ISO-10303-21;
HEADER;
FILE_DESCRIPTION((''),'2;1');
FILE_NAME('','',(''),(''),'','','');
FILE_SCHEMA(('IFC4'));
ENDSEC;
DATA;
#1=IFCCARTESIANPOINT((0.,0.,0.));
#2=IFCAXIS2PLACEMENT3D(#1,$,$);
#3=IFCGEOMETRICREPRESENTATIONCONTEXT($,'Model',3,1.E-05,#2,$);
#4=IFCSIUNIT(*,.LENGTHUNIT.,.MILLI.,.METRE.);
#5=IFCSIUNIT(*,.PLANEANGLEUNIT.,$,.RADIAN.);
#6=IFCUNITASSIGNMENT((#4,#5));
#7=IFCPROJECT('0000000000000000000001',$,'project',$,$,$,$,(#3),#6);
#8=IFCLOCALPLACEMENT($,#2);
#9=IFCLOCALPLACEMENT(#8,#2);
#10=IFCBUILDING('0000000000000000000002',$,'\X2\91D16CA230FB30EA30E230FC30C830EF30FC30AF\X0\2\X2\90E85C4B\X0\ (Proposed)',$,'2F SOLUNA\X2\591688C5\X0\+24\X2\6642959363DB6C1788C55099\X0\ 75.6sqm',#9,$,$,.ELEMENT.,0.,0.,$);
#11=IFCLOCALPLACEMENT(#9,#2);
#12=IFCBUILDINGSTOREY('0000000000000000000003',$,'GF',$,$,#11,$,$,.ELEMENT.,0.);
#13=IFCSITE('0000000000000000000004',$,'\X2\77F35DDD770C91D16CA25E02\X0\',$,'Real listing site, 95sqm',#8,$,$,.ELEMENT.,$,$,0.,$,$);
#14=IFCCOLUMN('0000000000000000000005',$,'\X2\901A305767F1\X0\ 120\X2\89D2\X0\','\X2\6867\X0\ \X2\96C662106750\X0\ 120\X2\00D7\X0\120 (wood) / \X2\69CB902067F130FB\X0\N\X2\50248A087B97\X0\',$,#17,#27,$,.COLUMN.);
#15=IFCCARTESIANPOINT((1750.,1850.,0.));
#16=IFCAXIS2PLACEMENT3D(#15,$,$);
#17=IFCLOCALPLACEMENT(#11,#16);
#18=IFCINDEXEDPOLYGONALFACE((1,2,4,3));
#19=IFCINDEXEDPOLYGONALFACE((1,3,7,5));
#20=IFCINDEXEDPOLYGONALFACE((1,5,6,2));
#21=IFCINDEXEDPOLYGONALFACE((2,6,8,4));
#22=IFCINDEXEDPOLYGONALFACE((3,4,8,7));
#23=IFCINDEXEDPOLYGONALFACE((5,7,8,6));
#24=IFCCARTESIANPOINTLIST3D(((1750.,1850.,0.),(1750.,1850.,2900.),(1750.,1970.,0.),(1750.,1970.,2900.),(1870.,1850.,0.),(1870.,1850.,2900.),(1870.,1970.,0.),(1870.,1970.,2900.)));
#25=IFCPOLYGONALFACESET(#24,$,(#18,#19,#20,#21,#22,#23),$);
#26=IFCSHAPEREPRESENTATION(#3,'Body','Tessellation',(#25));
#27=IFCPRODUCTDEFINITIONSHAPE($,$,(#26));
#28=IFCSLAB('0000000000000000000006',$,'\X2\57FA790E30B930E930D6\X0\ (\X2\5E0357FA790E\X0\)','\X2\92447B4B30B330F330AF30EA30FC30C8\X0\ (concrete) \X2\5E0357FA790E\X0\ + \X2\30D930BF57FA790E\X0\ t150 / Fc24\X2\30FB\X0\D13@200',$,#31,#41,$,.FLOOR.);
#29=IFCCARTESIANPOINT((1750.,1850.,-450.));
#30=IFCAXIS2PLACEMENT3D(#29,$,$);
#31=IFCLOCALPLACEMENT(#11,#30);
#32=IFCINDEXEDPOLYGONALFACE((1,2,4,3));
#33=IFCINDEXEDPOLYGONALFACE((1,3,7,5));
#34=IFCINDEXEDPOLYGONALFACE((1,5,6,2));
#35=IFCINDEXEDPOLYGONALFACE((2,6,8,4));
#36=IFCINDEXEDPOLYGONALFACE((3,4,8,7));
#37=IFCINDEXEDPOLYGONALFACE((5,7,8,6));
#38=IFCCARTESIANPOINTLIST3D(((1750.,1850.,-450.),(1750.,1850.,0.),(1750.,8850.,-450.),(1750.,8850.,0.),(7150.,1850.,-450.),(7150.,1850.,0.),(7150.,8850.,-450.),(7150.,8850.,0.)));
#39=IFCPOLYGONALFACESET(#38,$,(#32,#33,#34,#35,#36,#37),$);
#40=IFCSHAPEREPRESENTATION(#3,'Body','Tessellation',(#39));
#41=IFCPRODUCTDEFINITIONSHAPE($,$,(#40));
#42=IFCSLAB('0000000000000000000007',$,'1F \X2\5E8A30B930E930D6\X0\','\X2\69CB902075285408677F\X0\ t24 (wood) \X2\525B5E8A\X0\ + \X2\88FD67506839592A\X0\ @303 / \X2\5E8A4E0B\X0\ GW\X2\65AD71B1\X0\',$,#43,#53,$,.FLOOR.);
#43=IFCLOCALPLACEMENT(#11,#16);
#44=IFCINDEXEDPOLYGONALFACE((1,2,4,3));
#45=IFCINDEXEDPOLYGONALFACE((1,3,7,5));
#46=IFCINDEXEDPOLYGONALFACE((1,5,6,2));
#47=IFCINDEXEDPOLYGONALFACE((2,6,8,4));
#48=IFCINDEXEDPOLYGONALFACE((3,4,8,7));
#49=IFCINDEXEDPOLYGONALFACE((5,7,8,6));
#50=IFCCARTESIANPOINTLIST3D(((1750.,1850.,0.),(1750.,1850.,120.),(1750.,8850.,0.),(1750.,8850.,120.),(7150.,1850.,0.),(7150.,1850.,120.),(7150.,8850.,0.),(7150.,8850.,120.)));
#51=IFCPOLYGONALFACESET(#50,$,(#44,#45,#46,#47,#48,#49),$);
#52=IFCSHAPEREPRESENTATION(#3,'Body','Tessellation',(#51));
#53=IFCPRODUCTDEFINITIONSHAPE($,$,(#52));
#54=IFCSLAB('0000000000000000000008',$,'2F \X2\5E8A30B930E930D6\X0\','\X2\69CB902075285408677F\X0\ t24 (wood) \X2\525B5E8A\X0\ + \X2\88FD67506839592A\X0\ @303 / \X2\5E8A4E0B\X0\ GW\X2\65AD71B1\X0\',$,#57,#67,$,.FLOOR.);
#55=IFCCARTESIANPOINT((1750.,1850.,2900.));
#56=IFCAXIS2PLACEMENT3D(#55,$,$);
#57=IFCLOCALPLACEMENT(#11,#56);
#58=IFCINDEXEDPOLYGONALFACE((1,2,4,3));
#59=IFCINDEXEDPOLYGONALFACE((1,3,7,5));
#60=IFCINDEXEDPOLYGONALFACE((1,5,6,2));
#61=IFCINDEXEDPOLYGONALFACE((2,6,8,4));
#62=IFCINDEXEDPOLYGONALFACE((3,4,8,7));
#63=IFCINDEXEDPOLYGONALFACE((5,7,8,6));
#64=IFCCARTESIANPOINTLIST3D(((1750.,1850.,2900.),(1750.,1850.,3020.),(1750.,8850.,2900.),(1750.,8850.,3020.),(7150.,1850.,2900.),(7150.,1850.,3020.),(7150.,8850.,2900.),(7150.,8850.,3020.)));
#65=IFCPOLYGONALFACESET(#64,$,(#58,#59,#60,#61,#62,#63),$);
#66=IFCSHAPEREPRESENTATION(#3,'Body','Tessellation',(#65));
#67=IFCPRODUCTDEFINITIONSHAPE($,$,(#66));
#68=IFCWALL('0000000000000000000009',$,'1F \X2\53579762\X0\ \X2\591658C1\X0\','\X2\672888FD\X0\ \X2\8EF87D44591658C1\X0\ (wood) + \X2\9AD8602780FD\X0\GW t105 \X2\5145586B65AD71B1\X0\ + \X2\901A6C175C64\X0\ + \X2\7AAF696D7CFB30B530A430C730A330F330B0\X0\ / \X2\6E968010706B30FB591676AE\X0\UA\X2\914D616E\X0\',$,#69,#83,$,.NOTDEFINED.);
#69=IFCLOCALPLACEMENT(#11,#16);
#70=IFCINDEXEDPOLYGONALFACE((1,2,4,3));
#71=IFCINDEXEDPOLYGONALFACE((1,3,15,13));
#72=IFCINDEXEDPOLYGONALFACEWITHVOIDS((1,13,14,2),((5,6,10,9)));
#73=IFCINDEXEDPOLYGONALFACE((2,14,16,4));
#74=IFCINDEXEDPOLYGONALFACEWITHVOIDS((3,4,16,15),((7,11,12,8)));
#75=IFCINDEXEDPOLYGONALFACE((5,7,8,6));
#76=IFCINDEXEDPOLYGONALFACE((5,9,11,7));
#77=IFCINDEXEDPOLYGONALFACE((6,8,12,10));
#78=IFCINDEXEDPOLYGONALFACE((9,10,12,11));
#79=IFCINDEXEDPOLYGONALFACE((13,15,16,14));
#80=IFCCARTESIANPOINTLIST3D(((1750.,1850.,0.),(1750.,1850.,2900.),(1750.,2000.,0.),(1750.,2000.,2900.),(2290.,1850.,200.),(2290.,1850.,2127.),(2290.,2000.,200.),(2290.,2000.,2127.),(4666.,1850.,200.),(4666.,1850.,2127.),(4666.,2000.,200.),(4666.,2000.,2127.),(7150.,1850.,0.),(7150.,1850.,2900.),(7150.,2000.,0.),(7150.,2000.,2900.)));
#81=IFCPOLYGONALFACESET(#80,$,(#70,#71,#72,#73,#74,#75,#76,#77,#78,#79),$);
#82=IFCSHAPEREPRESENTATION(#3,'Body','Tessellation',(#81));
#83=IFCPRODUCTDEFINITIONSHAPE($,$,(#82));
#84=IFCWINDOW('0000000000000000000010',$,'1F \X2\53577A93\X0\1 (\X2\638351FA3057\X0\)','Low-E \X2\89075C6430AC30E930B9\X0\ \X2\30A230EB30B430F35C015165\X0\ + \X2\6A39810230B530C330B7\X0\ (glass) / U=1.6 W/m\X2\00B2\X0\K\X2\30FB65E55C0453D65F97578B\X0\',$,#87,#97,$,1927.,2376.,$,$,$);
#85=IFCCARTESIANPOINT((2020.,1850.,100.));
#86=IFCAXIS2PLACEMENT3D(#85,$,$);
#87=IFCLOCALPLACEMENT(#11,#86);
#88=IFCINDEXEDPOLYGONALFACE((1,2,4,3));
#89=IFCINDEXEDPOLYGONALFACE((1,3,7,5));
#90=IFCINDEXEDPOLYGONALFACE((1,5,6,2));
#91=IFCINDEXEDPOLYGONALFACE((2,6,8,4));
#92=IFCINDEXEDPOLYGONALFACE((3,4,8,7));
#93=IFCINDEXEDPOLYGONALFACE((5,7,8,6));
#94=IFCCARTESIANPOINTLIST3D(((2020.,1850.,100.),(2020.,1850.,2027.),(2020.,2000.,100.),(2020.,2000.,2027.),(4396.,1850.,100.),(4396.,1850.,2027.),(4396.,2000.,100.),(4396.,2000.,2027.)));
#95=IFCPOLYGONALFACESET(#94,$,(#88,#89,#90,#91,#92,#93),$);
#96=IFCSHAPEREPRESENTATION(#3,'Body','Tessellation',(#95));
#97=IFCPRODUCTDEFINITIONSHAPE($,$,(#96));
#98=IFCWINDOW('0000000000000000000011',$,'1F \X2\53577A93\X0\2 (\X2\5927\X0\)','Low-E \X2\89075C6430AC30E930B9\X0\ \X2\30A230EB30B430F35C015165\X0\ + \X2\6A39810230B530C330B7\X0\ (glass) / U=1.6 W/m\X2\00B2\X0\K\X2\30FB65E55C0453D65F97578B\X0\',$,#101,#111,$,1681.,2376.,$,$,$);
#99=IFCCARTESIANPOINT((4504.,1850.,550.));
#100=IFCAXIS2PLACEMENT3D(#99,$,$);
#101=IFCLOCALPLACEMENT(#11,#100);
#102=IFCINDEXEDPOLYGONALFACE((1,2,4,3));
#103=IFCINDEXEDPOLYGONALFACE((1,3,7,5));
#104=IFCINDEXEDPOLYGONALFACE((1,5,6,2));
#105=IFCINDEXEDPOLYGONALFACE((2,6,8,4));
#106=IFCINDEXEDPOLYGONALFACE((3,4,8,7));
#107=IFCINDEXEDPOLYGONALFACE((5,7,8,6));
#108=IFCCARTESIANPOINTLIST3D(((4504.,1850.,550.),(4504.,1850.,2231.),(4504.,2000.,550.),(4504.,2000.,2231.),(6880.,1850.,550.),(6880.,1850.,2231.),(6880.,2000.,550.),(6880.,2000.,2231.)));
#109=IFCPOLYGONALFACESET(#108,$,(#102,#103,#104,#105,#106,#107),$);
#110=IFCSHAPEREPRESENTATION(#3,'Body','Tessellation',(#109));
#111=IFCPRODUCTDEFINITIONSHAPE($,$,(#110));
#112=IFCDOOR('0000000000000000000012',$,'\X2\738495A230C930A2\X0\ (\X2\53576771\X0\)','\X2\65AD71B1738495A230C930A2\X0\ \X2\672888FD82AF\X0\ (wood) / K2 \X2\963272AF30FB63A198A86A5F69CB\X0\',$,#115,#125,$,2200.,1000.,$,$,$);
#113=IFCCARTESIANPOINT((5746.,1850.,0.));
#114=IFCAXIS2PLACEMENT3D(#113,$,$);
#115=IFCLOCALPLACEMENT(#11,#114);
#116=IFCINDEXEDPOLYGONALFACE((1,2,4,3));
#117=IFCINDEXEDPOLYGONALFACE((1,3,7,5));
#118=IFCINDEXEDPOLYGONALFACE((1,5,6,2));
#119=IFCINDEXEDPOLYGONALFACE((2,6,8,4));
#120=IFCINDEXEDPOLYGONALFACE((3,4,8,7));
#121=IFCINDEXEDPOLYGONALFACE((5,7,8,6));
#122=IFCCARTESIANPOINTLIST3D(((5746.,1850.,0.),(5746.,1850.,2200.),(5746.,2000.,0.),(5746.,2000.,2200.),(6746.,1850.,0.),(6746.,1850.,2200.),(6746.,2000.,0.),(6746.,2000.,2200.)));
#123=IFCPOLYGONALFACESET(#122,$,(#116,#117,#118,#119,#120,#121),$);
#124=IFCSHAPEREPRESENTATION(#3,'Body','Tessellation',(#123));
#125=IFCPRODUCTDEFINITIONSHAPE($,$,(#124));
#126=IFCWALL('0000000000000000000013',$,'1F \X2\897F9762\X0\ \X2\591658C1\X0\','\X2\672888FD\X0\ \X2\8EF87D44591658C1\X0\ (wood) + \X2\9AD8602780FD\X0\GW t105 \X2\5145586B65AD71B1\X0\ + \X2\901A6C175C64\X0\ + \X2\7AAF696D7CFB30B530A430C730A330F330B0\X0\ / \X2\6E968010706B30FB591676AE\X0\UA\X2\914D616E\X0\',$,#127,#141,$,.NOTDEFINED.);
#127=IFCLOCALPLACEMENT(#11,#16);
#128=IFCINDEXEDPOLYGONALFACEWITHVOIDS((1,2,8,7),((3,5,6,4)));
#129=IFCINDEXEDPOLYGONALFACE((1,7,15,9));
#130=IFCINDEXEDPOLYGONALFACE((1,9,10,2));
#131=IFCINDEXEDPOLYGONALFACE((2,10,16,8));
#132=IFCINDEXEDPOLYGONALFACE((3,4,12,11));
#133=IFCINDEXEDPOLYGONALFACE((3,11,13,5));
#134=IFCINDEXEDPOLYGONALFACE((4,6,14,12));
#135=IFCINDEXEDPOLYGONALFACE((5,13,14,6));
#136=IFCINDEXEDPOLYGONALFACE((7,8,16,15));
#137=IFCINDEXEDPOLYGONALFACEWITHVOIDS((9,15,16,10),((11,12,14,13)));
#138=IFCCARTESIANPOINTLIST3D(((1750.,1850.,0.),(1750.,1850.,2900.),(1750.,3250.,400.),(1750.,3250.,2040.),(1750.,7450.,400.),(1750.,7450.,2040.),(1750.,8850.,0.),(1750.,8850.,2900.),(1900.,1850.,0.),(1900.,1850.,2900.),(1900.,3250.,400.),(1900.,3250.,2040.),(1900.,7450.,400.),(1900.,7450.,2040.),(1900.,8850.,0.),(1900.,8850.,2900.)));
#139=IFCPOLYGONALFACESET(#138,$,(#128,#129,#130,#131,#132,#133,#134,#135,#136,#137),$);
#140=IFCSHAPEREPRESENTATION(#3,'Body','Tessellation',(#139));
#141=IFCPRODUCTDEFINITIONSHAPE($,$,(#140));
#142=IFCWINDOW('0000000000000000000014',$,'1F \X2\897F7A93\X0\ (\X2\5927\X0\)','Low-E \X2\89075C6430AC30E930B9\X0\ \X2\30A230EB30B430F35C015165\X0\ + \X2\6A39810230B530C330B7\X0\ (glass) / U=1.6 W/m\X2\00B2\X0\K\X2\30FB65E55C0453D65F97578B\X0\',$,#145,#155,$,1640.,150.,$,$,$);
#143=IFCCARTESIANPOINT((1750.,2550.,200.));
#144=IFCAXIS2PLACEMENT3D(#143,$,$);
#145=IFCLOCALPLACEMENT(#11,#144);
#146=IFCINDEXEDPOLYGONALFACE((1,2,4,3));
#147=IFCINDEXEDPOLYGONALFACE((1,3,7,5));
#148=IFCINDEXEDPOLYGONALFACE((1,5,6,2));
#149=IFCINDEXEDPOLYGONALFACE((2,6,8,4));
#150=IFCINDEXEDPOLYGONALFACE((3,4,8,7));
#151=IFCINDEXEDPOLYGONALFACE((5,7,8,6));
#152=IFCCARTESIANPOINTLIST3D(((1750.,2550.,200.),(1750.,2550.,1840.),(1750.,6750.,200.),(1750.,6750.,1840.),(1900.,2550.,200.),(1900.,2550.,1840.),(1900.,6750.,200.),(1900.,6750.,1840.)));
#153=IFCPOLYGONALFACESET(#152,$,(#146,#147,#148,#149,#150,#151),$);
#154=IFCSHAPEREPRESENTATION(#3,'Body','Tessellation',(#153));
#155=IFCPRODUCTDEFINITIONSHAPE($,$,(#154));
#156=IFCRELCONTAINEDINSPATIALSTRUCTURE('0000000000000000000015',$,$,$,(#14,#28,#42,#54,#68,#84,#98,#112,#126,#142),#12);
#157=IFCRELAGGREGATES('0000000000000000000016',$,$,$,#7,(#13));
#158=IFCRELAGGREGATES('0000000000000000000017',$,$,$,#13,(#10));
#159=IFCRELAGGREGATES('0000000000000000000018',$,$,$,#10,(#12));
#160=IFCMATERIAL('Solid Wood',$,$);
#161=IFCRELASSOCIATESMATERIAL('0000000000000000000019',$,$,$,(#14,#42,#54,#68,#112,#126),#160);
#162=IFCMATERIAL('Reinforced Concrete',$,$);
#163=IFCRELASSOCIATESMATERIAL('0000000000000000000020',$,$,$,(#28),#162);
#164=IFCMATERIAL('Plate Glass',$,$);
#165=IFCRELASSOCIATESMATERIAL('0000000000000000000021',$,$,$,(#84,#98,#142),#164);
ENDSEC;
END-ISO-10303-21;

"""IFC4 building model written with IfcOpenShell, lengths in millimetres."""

from ifc_helpers import new_model, si_unit, frame, frame_2d, origin, place, context, project, spatial, rectangle, extrude, material, element, fill, save


model = new_model("IFC4")

# Units and contexts
model_context = context("Model", 3, precision=1e-05, world=origin())
ifc_project = project(units=[si_unit("LENGTHUNIT", "METRE", prefix="MILLI"), si_unit("PLANEANGLEUNIT", "RADIAN")], contexts=[model_context])

# Site, building, storey
site_placement = place(None, origin())
site = spatial("IfcSite", under=ifc_project, at=site_placement, Name="石川県金沢市", ObjectType="Real listing site, 95sqm", CompositionType="ELEMENT", RefElevation=0.0)
building_placement = place(site_placement, origin())
building = spatial("IfcBuilding", under=site, at=building_placement, Name="金沢・リモートワーク2部屋 (Proposed)", ObjectType="2F SOLUNA外装+24時間換気装備 75.6sqm", CompositionType="ELEMENT", ElevationOfRefHeight=0.0, ElevationOfTerrain=0.0)
storey_placement = place(building_placement, origin())
storey = spatial("IfcBuildingStorey", under=building, at=storey_placement, Name="GF", CompositionType="ELEMENT", Elevation=0.0)

# Column
ifc_material_1 = material(Name="Solid Wood")
column_placement = place(storey_placement, frame((1750.0, 1850.0, 0.0)))
element("IfcColumn", 1, at=column_placement, inside=storey, material=ifc_material_1, Name="通し柱 120角", Description="桧 集成材 120×120 (wood) / 構造柱・N値計算", PredefinedType="COLUMN", context=model_context, shape_type="SweptSolid", body=[
    extrude(rectangle(XDim=120.0, YDim=120.0, at=frame_2d((60.0, 60.0))), frame((1750.0, 1850.0, 0.0)), (0.0, 0.0, 1.0), 2900.0),
])

# Slabs
ifc_material_2 = material(Name="Reinforced Concrete")
slab_1_placement = place(storey_placement, frame((1750.0, 1850.0, -450.0)))
element("IfcSlab", 2, at=slab_1_placement, inside=storey, material=ifc_material_2, Name="基礎スラブ (布基礎)", Description="鉄筋コンクリート (concrete) 布基礎 + ベタ基礎 t150 / Fc24・D13@200", PredefinedType="FLOOR", context=model_context, shape_type="SweptSolid", body=[
    extrude(rectangle(XDim=5400.0, YDim=7000.0, at=frame_2d((2700.0, 3500.0))), frame((1750.0, 1850.0, -450.0)), (0.0, 0.0, 1.0), 450.0),
])
slab_2_placement = place(storey_placement, frame((1750.0, 1850.0, 0.0)))
element("IfcSlab", 3, at=slab_2_placement, inside=storey, material=ifc_material_1, Name="1F 床スラブ", Description="構造用合板 t24 (wood) 剛床 + 製材根太 @303 / 床下 GW断熱", PredefinedType="FLOOR", context=model_context, shape_type="SweptSolid", body=[
    extrude(rectangle(XDim=5400.0, YDim=7000.0, at=frame_2d((2700.0, 3500.0))), frame((1750.0, 1850.0, 0.0)), (0.0, 0.0, 1.0), 120.0),
])
slab_3_placement = place(storey_placement, frame((1750.0, 1850.0, 2900.0)))
element("IfcSlab", 4, at=slab_3_placement, inside=storey, material=ifc_material_1, Name="2F 床スラブ", Description="構造用合板 t24 (wood) 剛床 + 製材根太 @303 / 床下 GW断熱", PredefinedType="FLOOR", context=model_context, shape_type="SweptSolid", body=[
    extrude(rectangle(XDim=5400.0, YDim=7000.0, at=frame_2d((2700.0, 3500.0))), frame((1750.0, 1850.0, 2900.0)), (0.0, 0.0, 1.0), 120.0),
])

# Wall, openings, windows, door
wall_1_placement = place(storey_placement, frame((1750.0, 1850.0, 0.0)))
wall_1 = element("IfcWall", 5, at=wall_1_placement, inside=storey, material=ifc_material_1, Name="1F 南面 外壁", Description="木製 軸組外壁 (wood) + 高性能GW t105 充填断熱 + 通気層 + 窯業系サイディング / 準耐火・外皮UA配慮", PredefinedType="NOTDEFINED", context=model_context, shape_type="SweptSolid", body=[
    extrude(rectangle(XDim=5400.0, YDim=150.0, at=frame_2d((2700.0, 75.0))), frame((1750.0, 1850.0, 0.0)), (0.0, 0.0, 1.0), 2900.0),
])
opening_1_placement = place(storey_placement, frame((2020.0, 1850.0, 100.0)))
opening_1 = element("IfcOpeningElement", 6, at=opening_1_placement, cuts=wall_1, PredefinedType="NOTDEFINED", context=model_context, shape_type="SweptSolid", body=[
    extrude(rectangle(XDim=2376.0, YDim=150.0, at=frame_2d((1188.0, 75.0))), frame((2020.0, 1850.0, 100.0)), (0.0, 0.0, 1.0), 1927.0),
])
opening_2_placement = place(storey_placement, frame((4504.0, 1850.0, 550.0)))
opening_2 = element("IfcOpeningElement", 7, at=opening_2_placement, cuts=wall_1, PredefinedType="NOTDEFINED", context=model_context, shape_type="SweptSolid", body=[
    extrude(rectangle(XDim=2376.0, YDim=150.0, at=frame_2d((1188.0, 75.0))), frame((4504.0, 1850.0, 550.0)), (0.0, 0.0, 1.0), 1681.0),
])
opening_3_placement = place(storey_placement, frame((5746.0, 1850.0, 0.0)))
opening_3 = element("IfcOpeningElement", 8, at=opening_3_placement, cuts=wall_1, PredefinedType="NOTDEFINED", context=model_context, shape_type="SweptSolid", body=[
    extrude(rectangle(XDim=1000.0, YDim=150.0, at=frame_2d((500.0, 75.0))), frame((5746.0, 1850.0, 0.0)), (0.0, 0.0, 1.0), 2200.0),
])
ifc_material_3 = material(Name="Plate Glass")
window_1_placement = place(storey_placement, frame((2020.0, 1850.0, 100.0)))
window_1 = element("IfcWindow", 9, at=window_1_placement, inside=storey, material=ifc_material_3, Name="1F 南窓1 (掃出し)", Description="Low-E 複層ガラス アルゴン封入 + 樹脂サッシ (glass) / U=1.6 W/m²K・日射取得型", OverallHeight=1927.0, OverallWidth=2376.0, context=model_context, shape_type="SweptSolid", body=[
    extrude(rectangle(XDim=2376.0, YDim=150.0, at=frame_2d((1188.0, 75.0))), frame((2020.0, 1850.0, 100.0)), (0.0, 0.0, 1.0), 1927.0),
])
fill(opening_1, window_1)
window_2_placement = place(storey_placement, frame((4504.0, 1850.0, 550.0)))
window_2 = element("IfcWindow", 10, at=window_2_placement, inside=storey, material=ifc_material_3, Name="1F 南窓2 (大)", Description="Low-E 複層ガラス アルゴン封入 + 樹脂サッシ (glass) / U=1.6 W/m²K・日射取得型", OverallHeight=1681.0, OverallWidth=2376.0, context=model_context, shape_type="SweptSolid", body=[
    extrude(rectangle(XDim=2376.0, YDim=150.0, at=frame_2d((1188.0, 75.0))), frame((4504.0, 1850.0, 550.0)), (0.0, 0.0, 1.0), 1681.0),
])
fill(opening_2, window_2)
door_placement = place(storey_placement, frame((5746.0, 1850.0, 0.0)))
door = element("IfcDoor", 11, at=door_placement, inside=storey, material=ifc_material_1, Name="玄関ドア (南東)", Description="断熱玄関ドア 木製芯 (wood) / K2 防犯・採風機構", OverallHeight=2200.0, OverallWidth=1000.0, context=model_context, shape_type="SweptSolid", body=[
    extrude(rectangle(XDim=1000.0, YDim=150.0, at=frame_2d((500.0, 75.0))), frame((5746.0, 1850.0, 0.0)), (0.0, 0.0, 1.0), 2200.0),
])
fill(opening_3, door)

# Wall, opening, window
wall_2_placement = place(storey_placement, frame((1750.0, 1850.0, 0.0)))
wall_2 = element("IfcWall", 12, at=wall_2_placement, inside=storey, material=ifc_material_1, Name="1F 西面 外壁", Description="木製 軸組外壁 (wood) + 高性能GW t105 充填断熱 + 通気層 + 窯業系サイディング / 準耐火・外皮UA配慮", PredefinedType="NOTDEFINED", context=model_context, shape_type="SweptSolid", body=[
    extrude(rectangle(XDim=150.0, YDim=7000.0, at=frame_2d((75.0, 3500.0))), frame((1750.0, 1850.0, 0.0)), (0.0, 0.0, 1.0), 2900.0),
])
opening_4_placement = place(storey_placement, frame((1750.0, 2550.0, 200.0)))
opening_4 = element("IfcOpeningElement", 13, at=opening_4_placement, cuts=wall_2, PredefinedType="NOTDEFINED", context=model_context, shape_type="SweptSolid", body=[
    extrude(rectangle(XDim=150.0, YDim=4200.0, at=frame_2d((75.0, 2100.0))), frame((1750.0, 2550.0, 200.0)), (0.0, 0.0, 1.0), 1640.0),
])
window_3_placement = place(storey_placement, frame((1750.0, 2550.0, 200.0)))
window_3 = element("IfcWindow", 14, at=window_3_placement, inside=storey, material=ifc_material_3, Name="1F 西窓 (大)", Description="Low-E 複層ガラス アルゴン封入 + 樹脂サッシ (glass) / U=1.6 W/m²K・日射取得型", OverallHeight=1640.0, OverallWidth=150.0, context=model_context, shape_type="SweptSolid", body=[
    extrude(rectangle(XDim=150.0, YDim=4200.0, at=frame_2d((75.0, 2100.0))), frame((1750.0, 2550.0, 200.0)), (0.0, 0.0, 1.0), 1640.0),
])
fill(opening_4, window_3)

save(model, "model.ifc")
